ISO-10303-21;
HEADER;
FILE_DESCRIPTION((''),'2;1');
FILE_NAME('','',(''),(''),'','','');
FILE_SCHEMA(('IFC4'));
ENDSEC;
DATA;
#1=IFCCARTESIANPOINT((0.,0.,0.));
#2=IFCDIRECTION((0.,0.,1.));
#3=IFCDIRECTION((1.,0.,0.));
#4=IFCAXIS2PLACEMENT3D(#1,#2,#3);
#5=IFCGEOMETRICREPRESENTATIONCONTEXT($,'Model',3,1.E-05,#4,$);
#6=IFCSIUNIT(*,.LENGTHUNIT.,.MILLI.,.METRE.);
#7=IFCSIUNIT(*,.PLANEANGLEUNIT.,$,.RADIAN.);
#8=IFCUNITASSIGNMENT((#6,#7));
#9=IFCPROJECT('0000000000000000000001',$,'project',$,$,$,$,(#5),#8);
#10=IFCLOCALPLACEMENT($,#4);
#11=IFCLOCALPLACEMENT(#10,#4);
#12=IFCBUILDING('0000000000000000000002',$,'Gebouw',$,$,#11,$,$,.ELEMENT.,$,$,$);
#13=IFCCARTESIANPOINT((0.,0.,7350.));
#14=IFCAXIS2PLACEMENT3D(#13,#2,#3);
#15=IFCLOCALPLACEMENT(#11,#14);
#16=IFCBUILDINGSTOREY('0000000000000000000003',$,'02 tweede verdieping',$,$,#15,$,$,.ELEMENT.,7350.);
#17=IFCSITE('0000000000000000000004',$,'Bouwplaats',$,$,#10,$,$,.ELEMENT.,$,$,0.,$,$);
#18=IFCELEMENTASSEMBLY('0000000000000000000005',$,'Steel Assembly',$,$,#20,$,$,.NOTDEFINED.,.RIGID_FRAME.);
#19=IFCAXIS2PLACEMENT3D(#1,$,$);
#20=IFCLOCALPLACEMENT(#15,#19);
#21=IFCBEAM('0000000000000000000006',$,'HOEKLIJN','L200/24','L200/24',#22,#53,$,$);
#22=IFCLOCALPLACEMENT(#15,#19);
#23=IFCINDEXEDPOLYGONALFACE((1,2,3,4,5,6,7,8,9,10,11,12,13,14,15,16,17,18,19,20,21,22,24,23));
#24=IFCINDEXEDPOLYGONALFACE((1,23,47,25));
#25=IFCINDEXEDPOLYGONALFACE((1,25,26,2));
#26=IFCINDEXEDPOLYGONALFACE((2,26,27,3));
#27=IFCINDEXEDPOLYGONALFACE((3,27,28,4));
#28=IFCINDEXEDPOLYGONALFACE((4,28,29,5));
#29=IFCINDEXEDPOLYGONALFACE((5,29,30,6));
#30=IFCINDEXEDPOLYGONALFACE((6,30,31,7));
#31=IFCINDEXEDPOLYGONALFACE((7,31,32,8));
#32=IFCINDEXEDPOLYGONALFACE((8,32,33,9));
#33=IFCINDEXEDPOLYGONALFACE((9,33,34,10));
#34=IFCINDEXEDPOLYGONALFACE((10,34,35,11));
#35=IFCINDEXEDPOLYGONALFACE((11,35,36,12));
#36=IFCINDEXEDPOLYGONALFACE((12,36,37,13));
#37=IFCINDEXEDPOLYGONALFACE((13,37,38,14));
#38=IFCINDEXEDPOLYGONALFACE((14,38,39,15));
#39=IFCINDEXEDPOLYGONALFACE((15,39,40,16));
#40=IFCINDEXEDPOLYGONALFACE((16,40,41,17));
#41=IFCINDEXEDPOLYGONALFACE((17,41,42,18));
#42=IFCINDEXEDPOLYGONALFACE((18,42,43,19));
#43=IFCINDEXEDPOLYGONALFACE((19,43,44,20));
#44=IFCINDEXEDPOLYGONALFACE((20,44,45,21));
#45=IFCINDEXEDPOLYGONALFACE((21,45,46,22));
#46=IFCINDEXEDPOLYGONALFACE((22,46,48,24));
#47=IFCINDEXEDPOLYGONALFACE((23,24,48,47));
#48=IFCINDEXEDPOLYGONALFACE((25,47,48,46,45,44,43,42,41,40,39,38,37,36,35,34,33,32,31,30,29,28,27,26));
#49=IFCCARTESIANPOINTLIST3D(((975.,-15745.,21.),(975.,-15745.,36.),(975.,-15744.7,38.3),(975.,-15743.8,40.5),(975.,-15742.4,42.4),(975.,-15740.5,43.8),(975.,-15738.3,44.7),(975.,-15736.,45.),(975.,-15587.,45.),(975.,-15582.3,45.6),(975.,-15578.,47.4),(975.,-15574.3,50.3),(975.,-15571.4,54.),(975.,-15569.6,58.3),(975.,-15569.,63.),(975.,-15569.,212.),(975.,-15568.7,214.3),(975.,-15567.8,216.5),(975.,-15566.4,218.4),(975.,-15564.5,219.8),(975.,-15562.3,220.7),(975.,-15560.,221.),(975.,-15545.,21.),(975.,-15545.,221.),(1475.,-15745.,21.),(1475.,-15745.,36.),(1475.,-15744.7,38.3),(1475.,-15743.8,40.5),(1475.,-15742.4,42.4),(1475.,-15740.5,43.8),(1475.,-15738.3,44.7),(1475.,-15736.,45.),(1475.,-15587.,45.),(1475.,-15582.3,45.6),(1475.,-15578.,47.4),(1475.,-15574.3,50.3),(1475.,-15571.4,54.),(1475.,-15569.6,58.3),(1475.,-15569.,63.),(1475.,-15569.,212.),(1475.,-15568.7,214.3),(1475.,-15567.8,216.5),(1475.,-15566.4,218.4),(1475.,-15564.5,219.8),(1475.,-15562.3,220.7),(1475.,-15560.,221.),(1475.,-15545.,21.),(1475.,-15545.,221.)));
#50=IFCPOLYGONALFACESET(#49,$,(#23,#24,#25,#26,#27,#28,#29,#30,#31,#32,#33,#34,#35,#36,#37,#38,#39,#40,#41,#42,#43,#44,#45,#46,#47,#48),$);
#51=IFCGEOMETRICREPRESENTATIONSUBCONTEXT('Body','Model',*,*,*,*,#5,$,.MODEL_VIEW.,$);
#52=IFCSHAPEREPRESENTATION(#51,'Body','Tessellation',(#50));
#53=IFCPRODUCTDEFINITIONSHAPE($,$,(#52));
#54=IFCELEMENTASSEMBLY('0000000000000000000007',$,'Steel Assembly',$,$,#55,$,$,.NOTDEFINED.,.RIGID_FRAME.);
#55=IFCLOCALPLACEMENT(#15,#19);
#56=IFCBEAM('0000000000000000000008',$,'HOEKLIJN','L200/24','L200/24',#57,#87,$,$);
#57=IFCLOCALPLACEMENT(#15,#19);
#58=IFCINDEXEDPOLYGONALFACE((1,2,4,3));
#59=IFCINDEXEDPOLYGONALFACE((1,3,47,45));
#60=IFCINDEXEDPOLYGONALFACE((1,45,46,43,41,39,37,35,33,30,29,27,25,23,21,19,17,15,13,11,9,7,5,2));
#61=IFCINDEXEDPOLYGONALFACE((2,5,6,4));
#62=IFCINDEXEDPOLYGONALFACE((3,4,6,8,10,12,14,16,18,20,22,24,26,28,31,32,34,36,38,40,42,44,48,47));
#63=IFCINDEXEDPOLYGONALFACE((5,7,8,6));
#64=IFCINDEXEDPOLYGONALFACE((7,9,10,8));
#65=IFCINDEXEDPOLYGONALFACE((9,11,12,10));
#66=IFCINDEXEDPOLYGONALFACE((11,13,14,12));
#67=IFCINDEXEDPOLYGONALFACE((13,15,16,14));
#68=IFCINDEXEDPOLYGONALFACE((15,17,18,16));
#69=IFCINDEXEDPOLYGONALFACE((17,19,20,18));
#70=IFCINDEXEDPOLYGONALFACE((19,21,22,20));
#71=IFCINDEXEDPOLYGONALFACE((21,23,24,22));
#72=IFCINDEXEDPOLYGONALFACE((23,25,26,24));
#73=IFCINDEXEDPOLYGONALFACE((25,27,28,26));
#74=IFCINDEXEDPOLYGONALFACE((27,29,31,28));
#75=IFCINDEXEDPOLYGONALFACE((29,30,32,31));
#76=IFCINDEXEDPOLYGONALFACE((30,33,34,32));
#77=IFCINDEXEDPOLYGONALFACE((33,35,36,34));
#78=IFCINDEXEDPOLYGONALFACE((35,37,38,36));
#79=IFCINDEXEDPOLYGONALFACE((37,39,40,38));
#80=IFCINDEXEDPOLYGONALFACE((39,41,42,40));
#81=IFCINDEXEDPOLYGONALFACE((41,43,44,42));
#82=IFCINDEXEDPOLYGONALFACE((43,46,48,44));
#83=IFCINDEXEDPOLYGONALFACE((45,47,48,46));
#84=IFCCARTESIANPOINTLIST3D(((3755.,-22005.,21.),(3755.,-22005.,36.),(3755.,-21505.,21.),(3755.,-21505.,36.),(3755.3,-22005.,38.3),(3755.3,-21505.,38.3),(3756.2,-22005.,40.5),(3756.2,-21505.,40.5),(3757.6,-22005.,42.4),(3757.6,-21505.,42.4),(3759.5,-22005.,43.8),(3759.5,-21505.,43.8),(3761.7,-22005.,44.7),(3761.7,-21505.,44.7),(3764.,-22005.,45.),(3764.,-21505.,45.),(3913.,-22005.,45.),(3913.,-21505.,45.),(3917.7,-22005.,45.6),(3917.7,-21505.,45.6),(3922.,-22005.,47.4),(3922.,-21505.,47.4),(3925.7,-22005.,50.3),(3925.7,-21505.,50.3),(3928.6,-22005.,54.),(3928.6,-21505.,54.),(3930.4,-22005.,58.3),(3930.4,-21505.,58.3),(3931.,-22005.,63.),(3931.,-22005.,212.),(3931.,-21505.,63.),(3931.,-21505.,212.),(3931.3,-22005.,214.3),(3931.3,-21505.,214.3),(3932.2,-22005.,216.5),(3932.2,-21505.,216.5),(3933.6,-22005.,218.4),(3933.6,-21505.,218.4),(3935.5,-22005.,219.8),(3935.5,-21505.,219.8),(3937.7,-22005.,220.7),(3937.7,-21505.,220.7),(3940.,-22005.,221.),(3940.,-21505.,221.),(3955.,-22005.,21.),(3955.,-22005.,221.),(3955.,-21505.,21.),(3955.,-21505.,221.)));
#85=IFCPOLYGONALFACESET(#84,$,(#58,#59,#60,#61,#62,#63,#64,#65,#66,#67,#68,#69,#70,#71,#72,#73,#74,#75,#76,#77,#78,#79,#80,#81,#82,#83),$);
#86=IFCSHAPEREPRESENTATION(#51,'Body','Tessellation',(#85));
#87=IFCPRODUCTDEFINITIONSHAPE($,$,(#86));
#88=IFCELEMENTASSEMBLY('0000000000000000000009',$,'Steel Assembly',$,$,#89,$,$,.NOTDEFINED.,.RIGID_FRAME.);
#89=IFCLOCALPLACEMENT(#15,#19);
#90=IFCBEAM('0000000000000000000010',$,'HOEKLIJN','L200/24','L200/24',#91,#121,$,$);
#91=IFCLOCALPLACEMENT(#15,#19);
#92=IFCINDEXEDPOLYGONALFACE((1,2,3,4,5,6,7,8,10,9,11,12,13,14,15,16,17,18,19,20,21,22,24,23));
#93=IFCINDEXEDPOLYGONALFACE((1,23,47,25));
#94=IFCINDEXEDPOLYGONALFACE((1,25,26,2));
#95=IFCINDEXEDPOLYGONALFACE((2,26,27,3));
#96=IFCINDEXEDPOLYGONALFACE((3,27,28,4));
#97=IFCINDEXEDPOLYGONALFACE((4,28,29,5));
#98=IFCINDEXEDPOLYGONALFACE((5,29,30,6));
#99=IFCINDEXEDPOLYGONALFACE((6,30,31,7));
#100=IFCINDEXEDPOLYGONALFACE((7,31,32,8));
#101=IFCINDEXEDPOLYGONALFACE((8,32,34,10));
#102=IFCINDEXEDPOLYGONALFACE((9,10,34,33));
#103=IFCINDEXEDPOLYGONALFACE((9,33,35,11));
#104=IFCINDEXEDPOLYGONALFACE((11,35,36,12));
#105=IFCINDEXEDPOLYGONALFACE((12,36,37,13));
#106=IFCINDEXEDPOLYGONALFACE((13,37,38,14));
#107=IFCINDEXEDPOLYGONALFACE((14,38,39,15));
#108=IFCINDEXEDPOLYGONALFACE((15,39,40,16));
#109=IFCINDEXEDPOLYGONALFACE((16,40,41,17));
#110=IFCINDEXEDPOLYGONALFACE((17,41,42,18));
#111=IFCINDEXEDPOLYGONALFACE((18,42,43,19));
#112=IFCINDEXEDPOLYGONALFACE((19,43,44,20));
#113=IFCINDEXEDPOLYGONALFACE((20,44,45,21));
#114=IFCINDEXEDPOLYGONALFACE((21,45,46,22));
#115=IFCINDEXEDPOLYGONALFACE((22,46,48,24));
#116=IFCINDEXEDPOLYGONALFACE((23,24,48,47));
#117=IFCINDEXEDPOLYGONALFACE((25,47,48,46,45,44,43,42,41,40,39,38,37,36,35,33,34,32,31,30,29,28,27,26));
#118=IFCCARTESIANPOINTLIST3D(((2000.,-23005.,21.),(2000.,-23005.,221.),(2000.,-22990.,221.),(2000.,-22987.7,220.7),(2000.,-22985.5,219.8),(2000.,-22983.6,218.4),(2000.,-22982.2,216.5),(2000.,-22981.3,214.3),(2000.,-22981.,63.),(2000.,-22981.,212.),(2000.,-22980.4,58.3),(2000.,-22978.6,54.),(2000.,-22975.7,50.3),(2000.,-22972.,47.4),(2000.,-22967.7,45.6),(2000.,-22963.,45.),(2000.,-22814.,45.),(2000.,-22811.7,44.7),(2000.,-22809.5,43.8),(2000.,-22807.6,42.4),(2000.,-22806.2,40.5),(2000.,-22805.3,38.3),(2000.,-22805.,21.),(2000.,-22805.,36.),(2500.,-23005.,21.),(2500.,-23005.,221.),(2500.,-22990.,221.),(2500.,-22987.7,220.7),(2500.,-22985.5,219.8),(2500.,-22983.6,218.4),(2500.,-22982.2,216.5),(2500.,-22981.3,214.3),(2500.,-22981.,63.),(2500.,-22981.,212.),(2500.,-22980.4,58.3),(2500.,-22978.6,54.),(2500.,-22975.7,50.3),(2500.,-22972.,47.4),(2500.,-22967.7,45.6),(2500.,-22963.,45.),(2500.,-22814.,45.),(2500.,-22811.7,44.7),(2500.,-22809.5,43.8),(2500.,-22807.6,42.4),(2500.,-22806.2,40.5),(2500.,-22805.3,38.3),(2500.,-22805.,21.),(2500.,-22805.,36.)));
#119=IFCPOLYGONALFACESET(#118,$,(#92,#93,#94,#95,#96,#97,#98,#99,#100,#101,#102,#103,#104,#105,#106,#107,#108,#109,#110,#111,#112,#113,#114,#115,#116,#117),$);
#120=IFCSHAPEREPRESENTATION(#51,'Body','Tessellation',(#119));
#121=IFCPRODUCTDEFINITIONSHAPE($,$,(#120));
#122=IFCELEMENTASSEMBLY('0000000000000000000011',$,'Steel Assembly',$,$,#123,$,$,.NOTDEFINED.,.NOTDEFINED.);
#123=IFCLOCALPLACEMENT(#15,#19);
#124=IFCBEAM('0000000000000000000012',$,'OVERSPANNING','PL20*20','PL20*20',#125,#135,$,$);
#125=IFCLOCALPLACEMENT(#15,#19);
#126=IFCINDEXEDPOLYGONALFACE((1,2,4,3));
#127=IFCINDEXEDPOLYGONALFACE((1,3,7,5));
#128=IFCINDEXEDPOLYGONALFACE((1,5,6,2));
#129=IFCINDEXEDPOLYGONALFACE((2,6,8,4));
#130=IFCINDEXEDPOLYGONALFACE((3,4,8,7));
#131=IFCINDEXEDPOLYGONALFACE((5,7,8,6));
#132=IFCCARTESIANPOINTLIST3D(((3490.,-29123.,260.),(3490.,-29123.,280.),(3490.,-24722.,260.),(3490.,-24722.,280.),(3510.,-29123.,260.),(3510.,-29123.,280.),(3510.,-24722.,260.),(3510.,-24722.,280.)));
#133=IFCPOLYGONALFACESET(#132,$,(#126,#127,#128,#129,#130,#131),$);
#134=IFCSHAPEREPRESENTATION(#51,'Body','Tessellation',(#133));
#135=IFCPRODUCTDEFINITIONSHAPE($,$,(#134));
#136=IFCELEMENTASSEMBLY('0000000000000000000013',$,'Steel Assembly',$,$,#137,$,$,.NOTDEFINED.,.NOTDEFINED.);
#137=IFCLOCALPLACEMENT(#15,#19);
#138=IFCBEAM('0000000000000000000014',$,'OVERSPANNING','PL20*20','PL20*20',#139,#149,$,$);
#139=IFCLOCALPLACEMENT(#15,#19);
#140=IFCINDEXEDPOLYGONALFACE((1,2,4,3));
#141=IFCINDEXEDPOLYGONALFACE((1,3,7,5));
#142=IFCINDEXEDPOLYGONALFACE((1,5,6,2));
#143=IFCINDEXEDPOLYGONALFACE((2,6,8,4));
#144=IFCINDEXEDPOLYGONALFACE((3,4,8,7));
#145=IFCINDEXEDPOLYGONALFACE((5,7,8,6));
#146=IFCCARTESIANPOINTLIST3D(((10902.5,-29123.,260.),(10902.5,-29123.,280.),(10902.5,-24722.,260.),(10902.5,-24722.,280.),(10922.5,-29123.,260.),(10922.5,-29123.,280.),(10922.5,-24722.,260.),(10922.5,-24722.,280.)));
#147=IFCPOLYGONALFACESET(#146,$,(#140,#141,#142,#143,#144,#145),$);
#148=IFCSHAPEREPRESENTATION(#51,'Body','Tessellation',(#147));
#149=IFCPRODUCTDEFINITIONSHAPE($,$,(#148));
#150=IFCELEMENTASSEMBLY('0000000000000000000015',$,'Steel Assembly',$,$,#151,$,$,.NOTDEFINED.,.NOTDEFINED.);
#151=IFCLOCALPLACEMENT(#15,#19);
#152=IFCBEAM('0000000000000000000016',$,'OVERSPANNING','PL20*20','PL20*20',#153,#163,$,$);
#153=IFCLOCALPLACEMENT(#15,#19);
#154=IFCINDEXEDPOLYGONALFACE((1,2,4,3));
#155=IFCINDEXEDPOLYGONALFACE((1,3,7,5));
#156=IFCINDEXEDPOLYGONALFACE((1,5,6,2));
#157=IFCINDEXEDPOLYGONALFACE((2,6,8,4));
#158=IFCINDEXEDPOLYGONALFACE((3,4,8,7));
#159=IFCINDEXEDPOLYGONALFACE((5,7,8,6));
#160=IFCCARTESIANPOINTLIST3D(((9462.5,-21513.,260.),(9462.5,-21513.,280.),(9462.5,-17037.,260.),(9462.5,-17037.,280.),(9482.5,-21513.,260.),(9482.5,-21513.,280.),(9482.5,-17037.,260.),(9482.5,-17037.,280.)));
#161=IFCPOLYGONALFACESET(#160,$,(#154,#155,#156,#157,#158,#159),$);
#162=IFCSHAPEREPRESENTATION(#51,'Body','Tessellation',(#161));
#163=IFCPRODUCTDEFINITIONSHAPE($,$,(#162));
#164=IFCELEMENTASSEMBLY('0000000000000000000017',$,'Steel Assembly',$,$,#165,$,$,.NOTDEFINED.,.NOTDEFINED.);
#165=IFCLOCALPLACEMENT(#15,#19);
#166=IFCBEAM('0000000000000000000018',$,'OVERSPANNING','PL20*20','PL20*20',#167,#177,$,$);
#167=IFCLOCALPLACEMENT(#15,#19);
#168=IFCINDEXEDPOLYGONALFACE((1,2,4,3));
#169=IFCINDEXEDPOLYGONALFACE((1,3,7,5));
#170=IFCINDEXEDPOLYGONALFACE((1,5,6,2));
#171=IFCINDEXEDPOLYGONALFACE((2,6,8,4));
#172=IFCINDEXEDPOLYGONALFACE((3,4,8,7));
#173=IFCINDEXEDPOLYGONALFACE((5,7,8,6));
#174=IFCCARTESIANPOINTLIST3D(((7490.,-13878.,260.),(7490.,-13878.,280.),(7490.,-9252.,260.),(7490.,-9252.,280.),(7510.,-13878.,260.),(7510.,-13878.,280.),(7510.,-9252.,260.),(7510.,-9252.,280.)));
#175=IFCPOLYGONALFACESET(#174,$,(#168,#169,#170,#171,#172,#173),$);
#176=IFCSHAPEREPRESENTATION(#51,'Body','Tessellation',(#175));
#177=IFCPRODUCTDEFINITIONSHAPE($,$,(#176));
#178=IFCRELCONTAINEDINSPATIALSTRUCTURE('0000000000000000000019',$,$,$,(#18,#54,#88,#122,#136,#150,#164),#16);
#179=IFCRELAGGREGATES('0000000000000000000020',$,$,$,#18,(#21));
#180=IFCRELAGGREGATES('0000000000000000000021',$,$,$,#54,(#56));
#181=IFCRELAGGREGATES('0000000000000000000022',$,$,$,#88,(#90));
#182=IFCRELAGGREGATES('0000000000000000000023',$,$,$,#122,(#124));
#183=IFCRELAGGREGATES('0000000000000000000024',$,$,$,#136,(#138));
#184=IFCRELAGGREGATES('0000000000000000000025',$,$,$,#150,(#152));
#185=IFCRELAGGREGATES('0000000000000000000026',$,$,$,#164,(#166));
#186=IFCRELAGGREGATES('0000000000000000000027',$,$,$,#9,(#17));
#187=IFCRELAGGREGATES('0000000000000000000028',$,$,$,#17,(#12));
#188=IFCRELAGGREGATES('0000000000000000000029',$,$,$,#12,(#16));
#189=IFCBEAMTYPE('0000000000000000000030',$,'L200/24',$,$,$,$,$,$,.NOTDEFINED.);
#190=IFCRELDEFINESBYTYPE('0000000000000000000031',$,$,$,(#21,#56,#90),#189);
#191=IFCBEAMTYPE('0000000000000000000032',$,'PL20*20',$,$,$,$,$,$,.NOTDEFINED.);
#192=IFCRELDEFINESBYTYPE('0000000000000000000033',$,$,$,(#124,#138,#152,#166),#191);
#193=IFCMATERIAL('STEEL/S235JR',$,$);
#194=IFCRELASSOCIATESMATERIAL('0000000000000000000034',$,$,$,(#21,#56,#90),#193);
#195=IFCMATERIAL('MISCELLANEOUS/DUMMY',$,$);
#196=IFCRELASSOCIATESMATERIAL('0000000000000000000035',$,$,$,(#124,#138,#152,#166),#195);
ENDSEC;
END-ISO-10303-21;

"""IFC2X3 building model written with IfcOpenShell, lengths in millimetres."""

from ifc_helpers import new_model, si_unit, frame, origin_with_axes, origin_2d_with_axis, place, context, subcontext, project, spatial, rectangle, l_section, extrude, material, type_object, element, aggregate, save


model = new_model("IFC2X3")

# Units and contexts
model_context = context("Model", 3, precision=1e-05, world=origin_with_axes())
body_context = subcontext(model_context, "Body", "Model", "MODEL_VIEW")
ifc_project = project(units=[si_unit("LENGTHUNIT", "METRE", prefix="MILLI"), si_unit("PLANEANGLEUNIT", "RADIAN")], contexts=[model_context])

# Site, building, storey
site_placement = place(None, origin_with_axes())
site = spatial("IfcSite", under=ifc_project, at=site_placement, Name="Bouwplaats", CompositionType="ELEMENT", RefElevation=0.0)
building_placement = place(site_placement, origin_with_axes())
building = spatial("IfcBuilding", under=site, at=building_placement, Name="Gebouw", CompositionType="ELEMENT")
storey_placement = place(building_placement, frame((0.0, 0.0, 7350.0), z_axis=(0.0, 0.0, 1.0), x_axis=(1.0, 0.0, 0.0)))
storey = spatial("IfcBuildingStorey", under=building, at=storey_placement, Name="02 tweede verdieping", CompositionType="ELEMENT", Elevation=7350.0)

# Element assemblies, beams
ifc_material_1 = material(Name="MISCELLANEOUS/DUMMY")
ifc_material_2 = material(Name="STEEL/S235JR")
beam_type_1 = type_object("IfcBeamType", Name="L200/24", PredefinedType="NOTDEFINED")
assembly_1_placement = place(storey_placement, origin_with_axes())
assembly_1 = element("IfcElementAssembly", 1, at=assembly_1_placement, inside=storey, Name="Steel Assembly", AssemblyPlace="NOTDEFINED", PredefinedType="RIGID_FRAME")
beam_1_placement = place(assembly_1_placement, frame((1475.0, -15645.0, 121.0), z_axis=(0.0, -1.0, 0.0), x_axis=(-1.0, 0.0, 0.0)))
beam_1 = element("IfcBeam", 2, at=beam_1_placement, type_object=beam_type_1, material=ifc_material_2, Name="HOEKLIJN", Description="L200/24", ObjectType="L200/24", context=body_context, shape_type="SweptSolid", body=[
    extrude(l_section(Depth=200.0, Width=200.0, Thickness=24.0, FilletRadius=18.0, EdgeRadius=9.0, at=origin_2d_with_axis()), frame((500.0, 0.0, 0.0), z_axis=(-1.0, 0.0, 0.0), x_axis=(0.0, -1.0, 0.0)), (0.0, 0.0, 1.0), 500.0),
])
aggregate(assembly_1, [beam_1])
assembly_2_placement = place(storey_placement, origin_with_axes())
assembly_2 = element("IfcElementAssembly", 3, at=assembly_2_placement, inside=storey, Name="Steel Assembly", AssemblyPlace="NOTDEFINED", PredefinedType="RIGID_FRAME")
beam_2_placement = place(assembly_2_placement, frame((3855.0, -22005.0, 121.0), z_axis=(-1.0, 0.0, 0.0), x_axis=(0.0, 1.0, 0.0)))
beam_2 = element("IfcBeam", 4, at=beam_2_placement, type_object=beam_type_1, material=ifc_material_2, Name="HOEKLIJN", Description="L200/24", ObjectType="L200/24", context=body_context, shape_type="SweptSolid", body=[
    extrude(l_section(Depth=200.0, Width=200.0, Thickness=24.0, FilletRadius=18.0, EdgeRadius=9.0, at=origin_2d_with_axis()), frame((500.0, 0.0, 0.0), z_axis=(-1.0, 0.0, 0.0), x_axis=(0.0, -1.0, 0.0)), (0.0, 0.0, 1.0), 500.0),
])
aggregate(assembly_2, [beam_2])
assembly_3_placement = place(storey_placement, origin_with_axes())
assembly_3 = element("IfcElementAssembly", 5, at=assembly_3_placement, inside=storey, Name="Steel Assembly", AssemblyPlace="NOTDEFINED", PredefinedType="RIGID_FRAME")
beam_3_placement = place(assembly_3_placement, frame((2000.0, -22905.0, 121.0), z_axis=(0.0, 1.0, 0.0), x_axis=(1.0, 0.0, 0.0)))
beam_3 = element("IfcBeam", 6, at=beam_3_placement, type_object=beam_type_1, material=ifc_material_2, Name="HOEKLIJN", Description="L200/24", ObjectType="L200/24", context=body_context, shape_type="SweptSolid", body=[
    extrude(l_section(Depth=200.0, Width=200.0, Thickness=24.0, FilletRadius=18.0, EdgeRadius=9.0, at=origin_2d_with_axis()), frame((500.0, 0.0, 0.0), z_axis=(-1.0, 0.0, 0.0), x_axis=(0.0, -1.0, 0.0)), (0.0, 0.0, 1.0), 500.0),
])
aggregate(assembly_3, [beam_3])
assembly_4_placement = place(storey_placement, origin_with_axes())
assembly_4 = element("IfcElementAssembly", 7, at=assembly_4_placement, inside=storey, Name="Steel Assembly", AssemblyPlace="NOTDEFINED", PredefinedType="NOTDEFINED")
beam_type_2 = type_object("IfcBeamType", Name="PL20*20", PredefinedType="NOTDEFINED")
beam_4_placement = place(assembly_4_placement, frame((3500.0, -29123.0, 270.0), z_axis=(-1.0, 0.0, 0.0), x_axis=(0.0, 1.0, 0.0)))
beam_4 = element("IfcBeam", 8, at=beam_4_placement, type_object=beam_type_2, material=ifc_material_1, Name="OVERSPANNING", Description="PL20*20", ObjectType="PL20*20", context=body_context, shape_type="SweptSolid", body=[
    extrude(rectangle(XDim=20.0, YDim=20.0, at=origin_2d_with_axis()), frame((4401.0, 0.0, 0.0), z_axis=(-1.0, 0.0, 0.0), x_axis=(0.0, -1.0, 0.0)), (0.0, 0.0, 1.0), 4401.0),
])
assembly_5_placement = place(storey_placement, origin_with_axes())
assembly_5 = element("IfcElementAssembly", 9, at=assembly_5_placement, inside=storey, Name="Steel Assembly", AssemblyPlace="NOTDEFINED", PredefinedType="NOTDEFINED")
beam_5_placement = place(assembly_5_placement, frame((10912.5, -29123.0, 270.0), z_axis=(-1.0, 0.0, 0.0), x_axis=(0.0, 1.0, 0.0)))
beam_5 = element("IfcBeam", 10, at=beam_5_placement, type_object=beam_type_2, material=ifc_material_1, Name="OVERSPANNING", Description="PL20*20", ObjectType="PL20*20", context=body_context, shape_type="SweptSolid", body=[
    extrude(rectangle(XDim=20.0, YDim=20.0, at=origin_2d_with_axis()), frame((4401.0, 0.0, 0.0), z_axis=(-1.0, 0.0, 0.0), x_axis=(0.0, -1.0, 0.0)), (0.0, 0.0, 1.0), 4401.0),
])
assembly_6_placement = place(storey_placement, origin_with_axes())
assembly_6 = element("IfcElementAssembly", 11, at=assembly_6_placement, inside=storey, Name="Steel Assembly", AssemblyPlace="NOTDEFINED", PredefinedType="NOTDEFINED")
beam_6_placement = place(assembly_6_placement, frame((9472.5, -21513.0, 270.0), z_axis=(-1.0, 0.0, 0.0), x_axis=(0.0, 1.0, 0.0)))
beam_6 = element("IfcBeam", 12, at=beam_6_placement, type_object=beam_type_2, material=ifc_material_1, Name="OVERSPANNING", Description="PL20*20", ObjectType="PL20*20", context=body_context, shape_type="SweptSolid", body=[
    extrude(rectangle(XDim=20.0, YDim=20.0, at=origin_2d_with_axis()), frame((4476.0, 0.0, 0.0), z_axis=(-1.0, 0.0, 0.0), x_axis=(0.0, -1.0, 0.0)), (0.0, 0.0, 1.0), 4476.0),
])
assembly_7_placement = place(storey_placement, origin_with_axes())
assembly_7 = element("IfcElementAssembly", 13, at=assembly_7_placement, inside=storey, Name="Steel Assembly", AssemblyPlace="NOTDEFINED", PredefinedType="NOTDEFINED")
beam_7_placement = place(assembly_7_placement, frame((7500.0, -13878.0, 270.0), z_axis=(-1.0, 0.0, 0.0), x_axis=(0.0, 1.0, 0.0)))
beam_7 = element("IfcBeam", 14, at=beam_7_placement, type_object=beam_type_2, material=ifc_material_1, Name="OVERSPANNING", Description="PL20*20", ObjectType="PL20*20", context=body_context, shape_type="SweptSolid", body=[
    extrude(rectangle(XDim=20.0, YDim=20.0, at=origin_2d_with_axis()), frame((4626.0, 0.0, 0.0), z_axis=(-1.0, 0.0, 0.0), x_axis=(0.0, -1.0, 0.0)), (0.0, 0.0, 1.0), 4626.0),
])

aggregate(assembly_4, [beam_4])
aggregate(assembly_5, [beam_5])
aggregate(assembly_6, [beam_6])
aggregate(assembly_7, [beam_7])

save(model, "model.ifc")
